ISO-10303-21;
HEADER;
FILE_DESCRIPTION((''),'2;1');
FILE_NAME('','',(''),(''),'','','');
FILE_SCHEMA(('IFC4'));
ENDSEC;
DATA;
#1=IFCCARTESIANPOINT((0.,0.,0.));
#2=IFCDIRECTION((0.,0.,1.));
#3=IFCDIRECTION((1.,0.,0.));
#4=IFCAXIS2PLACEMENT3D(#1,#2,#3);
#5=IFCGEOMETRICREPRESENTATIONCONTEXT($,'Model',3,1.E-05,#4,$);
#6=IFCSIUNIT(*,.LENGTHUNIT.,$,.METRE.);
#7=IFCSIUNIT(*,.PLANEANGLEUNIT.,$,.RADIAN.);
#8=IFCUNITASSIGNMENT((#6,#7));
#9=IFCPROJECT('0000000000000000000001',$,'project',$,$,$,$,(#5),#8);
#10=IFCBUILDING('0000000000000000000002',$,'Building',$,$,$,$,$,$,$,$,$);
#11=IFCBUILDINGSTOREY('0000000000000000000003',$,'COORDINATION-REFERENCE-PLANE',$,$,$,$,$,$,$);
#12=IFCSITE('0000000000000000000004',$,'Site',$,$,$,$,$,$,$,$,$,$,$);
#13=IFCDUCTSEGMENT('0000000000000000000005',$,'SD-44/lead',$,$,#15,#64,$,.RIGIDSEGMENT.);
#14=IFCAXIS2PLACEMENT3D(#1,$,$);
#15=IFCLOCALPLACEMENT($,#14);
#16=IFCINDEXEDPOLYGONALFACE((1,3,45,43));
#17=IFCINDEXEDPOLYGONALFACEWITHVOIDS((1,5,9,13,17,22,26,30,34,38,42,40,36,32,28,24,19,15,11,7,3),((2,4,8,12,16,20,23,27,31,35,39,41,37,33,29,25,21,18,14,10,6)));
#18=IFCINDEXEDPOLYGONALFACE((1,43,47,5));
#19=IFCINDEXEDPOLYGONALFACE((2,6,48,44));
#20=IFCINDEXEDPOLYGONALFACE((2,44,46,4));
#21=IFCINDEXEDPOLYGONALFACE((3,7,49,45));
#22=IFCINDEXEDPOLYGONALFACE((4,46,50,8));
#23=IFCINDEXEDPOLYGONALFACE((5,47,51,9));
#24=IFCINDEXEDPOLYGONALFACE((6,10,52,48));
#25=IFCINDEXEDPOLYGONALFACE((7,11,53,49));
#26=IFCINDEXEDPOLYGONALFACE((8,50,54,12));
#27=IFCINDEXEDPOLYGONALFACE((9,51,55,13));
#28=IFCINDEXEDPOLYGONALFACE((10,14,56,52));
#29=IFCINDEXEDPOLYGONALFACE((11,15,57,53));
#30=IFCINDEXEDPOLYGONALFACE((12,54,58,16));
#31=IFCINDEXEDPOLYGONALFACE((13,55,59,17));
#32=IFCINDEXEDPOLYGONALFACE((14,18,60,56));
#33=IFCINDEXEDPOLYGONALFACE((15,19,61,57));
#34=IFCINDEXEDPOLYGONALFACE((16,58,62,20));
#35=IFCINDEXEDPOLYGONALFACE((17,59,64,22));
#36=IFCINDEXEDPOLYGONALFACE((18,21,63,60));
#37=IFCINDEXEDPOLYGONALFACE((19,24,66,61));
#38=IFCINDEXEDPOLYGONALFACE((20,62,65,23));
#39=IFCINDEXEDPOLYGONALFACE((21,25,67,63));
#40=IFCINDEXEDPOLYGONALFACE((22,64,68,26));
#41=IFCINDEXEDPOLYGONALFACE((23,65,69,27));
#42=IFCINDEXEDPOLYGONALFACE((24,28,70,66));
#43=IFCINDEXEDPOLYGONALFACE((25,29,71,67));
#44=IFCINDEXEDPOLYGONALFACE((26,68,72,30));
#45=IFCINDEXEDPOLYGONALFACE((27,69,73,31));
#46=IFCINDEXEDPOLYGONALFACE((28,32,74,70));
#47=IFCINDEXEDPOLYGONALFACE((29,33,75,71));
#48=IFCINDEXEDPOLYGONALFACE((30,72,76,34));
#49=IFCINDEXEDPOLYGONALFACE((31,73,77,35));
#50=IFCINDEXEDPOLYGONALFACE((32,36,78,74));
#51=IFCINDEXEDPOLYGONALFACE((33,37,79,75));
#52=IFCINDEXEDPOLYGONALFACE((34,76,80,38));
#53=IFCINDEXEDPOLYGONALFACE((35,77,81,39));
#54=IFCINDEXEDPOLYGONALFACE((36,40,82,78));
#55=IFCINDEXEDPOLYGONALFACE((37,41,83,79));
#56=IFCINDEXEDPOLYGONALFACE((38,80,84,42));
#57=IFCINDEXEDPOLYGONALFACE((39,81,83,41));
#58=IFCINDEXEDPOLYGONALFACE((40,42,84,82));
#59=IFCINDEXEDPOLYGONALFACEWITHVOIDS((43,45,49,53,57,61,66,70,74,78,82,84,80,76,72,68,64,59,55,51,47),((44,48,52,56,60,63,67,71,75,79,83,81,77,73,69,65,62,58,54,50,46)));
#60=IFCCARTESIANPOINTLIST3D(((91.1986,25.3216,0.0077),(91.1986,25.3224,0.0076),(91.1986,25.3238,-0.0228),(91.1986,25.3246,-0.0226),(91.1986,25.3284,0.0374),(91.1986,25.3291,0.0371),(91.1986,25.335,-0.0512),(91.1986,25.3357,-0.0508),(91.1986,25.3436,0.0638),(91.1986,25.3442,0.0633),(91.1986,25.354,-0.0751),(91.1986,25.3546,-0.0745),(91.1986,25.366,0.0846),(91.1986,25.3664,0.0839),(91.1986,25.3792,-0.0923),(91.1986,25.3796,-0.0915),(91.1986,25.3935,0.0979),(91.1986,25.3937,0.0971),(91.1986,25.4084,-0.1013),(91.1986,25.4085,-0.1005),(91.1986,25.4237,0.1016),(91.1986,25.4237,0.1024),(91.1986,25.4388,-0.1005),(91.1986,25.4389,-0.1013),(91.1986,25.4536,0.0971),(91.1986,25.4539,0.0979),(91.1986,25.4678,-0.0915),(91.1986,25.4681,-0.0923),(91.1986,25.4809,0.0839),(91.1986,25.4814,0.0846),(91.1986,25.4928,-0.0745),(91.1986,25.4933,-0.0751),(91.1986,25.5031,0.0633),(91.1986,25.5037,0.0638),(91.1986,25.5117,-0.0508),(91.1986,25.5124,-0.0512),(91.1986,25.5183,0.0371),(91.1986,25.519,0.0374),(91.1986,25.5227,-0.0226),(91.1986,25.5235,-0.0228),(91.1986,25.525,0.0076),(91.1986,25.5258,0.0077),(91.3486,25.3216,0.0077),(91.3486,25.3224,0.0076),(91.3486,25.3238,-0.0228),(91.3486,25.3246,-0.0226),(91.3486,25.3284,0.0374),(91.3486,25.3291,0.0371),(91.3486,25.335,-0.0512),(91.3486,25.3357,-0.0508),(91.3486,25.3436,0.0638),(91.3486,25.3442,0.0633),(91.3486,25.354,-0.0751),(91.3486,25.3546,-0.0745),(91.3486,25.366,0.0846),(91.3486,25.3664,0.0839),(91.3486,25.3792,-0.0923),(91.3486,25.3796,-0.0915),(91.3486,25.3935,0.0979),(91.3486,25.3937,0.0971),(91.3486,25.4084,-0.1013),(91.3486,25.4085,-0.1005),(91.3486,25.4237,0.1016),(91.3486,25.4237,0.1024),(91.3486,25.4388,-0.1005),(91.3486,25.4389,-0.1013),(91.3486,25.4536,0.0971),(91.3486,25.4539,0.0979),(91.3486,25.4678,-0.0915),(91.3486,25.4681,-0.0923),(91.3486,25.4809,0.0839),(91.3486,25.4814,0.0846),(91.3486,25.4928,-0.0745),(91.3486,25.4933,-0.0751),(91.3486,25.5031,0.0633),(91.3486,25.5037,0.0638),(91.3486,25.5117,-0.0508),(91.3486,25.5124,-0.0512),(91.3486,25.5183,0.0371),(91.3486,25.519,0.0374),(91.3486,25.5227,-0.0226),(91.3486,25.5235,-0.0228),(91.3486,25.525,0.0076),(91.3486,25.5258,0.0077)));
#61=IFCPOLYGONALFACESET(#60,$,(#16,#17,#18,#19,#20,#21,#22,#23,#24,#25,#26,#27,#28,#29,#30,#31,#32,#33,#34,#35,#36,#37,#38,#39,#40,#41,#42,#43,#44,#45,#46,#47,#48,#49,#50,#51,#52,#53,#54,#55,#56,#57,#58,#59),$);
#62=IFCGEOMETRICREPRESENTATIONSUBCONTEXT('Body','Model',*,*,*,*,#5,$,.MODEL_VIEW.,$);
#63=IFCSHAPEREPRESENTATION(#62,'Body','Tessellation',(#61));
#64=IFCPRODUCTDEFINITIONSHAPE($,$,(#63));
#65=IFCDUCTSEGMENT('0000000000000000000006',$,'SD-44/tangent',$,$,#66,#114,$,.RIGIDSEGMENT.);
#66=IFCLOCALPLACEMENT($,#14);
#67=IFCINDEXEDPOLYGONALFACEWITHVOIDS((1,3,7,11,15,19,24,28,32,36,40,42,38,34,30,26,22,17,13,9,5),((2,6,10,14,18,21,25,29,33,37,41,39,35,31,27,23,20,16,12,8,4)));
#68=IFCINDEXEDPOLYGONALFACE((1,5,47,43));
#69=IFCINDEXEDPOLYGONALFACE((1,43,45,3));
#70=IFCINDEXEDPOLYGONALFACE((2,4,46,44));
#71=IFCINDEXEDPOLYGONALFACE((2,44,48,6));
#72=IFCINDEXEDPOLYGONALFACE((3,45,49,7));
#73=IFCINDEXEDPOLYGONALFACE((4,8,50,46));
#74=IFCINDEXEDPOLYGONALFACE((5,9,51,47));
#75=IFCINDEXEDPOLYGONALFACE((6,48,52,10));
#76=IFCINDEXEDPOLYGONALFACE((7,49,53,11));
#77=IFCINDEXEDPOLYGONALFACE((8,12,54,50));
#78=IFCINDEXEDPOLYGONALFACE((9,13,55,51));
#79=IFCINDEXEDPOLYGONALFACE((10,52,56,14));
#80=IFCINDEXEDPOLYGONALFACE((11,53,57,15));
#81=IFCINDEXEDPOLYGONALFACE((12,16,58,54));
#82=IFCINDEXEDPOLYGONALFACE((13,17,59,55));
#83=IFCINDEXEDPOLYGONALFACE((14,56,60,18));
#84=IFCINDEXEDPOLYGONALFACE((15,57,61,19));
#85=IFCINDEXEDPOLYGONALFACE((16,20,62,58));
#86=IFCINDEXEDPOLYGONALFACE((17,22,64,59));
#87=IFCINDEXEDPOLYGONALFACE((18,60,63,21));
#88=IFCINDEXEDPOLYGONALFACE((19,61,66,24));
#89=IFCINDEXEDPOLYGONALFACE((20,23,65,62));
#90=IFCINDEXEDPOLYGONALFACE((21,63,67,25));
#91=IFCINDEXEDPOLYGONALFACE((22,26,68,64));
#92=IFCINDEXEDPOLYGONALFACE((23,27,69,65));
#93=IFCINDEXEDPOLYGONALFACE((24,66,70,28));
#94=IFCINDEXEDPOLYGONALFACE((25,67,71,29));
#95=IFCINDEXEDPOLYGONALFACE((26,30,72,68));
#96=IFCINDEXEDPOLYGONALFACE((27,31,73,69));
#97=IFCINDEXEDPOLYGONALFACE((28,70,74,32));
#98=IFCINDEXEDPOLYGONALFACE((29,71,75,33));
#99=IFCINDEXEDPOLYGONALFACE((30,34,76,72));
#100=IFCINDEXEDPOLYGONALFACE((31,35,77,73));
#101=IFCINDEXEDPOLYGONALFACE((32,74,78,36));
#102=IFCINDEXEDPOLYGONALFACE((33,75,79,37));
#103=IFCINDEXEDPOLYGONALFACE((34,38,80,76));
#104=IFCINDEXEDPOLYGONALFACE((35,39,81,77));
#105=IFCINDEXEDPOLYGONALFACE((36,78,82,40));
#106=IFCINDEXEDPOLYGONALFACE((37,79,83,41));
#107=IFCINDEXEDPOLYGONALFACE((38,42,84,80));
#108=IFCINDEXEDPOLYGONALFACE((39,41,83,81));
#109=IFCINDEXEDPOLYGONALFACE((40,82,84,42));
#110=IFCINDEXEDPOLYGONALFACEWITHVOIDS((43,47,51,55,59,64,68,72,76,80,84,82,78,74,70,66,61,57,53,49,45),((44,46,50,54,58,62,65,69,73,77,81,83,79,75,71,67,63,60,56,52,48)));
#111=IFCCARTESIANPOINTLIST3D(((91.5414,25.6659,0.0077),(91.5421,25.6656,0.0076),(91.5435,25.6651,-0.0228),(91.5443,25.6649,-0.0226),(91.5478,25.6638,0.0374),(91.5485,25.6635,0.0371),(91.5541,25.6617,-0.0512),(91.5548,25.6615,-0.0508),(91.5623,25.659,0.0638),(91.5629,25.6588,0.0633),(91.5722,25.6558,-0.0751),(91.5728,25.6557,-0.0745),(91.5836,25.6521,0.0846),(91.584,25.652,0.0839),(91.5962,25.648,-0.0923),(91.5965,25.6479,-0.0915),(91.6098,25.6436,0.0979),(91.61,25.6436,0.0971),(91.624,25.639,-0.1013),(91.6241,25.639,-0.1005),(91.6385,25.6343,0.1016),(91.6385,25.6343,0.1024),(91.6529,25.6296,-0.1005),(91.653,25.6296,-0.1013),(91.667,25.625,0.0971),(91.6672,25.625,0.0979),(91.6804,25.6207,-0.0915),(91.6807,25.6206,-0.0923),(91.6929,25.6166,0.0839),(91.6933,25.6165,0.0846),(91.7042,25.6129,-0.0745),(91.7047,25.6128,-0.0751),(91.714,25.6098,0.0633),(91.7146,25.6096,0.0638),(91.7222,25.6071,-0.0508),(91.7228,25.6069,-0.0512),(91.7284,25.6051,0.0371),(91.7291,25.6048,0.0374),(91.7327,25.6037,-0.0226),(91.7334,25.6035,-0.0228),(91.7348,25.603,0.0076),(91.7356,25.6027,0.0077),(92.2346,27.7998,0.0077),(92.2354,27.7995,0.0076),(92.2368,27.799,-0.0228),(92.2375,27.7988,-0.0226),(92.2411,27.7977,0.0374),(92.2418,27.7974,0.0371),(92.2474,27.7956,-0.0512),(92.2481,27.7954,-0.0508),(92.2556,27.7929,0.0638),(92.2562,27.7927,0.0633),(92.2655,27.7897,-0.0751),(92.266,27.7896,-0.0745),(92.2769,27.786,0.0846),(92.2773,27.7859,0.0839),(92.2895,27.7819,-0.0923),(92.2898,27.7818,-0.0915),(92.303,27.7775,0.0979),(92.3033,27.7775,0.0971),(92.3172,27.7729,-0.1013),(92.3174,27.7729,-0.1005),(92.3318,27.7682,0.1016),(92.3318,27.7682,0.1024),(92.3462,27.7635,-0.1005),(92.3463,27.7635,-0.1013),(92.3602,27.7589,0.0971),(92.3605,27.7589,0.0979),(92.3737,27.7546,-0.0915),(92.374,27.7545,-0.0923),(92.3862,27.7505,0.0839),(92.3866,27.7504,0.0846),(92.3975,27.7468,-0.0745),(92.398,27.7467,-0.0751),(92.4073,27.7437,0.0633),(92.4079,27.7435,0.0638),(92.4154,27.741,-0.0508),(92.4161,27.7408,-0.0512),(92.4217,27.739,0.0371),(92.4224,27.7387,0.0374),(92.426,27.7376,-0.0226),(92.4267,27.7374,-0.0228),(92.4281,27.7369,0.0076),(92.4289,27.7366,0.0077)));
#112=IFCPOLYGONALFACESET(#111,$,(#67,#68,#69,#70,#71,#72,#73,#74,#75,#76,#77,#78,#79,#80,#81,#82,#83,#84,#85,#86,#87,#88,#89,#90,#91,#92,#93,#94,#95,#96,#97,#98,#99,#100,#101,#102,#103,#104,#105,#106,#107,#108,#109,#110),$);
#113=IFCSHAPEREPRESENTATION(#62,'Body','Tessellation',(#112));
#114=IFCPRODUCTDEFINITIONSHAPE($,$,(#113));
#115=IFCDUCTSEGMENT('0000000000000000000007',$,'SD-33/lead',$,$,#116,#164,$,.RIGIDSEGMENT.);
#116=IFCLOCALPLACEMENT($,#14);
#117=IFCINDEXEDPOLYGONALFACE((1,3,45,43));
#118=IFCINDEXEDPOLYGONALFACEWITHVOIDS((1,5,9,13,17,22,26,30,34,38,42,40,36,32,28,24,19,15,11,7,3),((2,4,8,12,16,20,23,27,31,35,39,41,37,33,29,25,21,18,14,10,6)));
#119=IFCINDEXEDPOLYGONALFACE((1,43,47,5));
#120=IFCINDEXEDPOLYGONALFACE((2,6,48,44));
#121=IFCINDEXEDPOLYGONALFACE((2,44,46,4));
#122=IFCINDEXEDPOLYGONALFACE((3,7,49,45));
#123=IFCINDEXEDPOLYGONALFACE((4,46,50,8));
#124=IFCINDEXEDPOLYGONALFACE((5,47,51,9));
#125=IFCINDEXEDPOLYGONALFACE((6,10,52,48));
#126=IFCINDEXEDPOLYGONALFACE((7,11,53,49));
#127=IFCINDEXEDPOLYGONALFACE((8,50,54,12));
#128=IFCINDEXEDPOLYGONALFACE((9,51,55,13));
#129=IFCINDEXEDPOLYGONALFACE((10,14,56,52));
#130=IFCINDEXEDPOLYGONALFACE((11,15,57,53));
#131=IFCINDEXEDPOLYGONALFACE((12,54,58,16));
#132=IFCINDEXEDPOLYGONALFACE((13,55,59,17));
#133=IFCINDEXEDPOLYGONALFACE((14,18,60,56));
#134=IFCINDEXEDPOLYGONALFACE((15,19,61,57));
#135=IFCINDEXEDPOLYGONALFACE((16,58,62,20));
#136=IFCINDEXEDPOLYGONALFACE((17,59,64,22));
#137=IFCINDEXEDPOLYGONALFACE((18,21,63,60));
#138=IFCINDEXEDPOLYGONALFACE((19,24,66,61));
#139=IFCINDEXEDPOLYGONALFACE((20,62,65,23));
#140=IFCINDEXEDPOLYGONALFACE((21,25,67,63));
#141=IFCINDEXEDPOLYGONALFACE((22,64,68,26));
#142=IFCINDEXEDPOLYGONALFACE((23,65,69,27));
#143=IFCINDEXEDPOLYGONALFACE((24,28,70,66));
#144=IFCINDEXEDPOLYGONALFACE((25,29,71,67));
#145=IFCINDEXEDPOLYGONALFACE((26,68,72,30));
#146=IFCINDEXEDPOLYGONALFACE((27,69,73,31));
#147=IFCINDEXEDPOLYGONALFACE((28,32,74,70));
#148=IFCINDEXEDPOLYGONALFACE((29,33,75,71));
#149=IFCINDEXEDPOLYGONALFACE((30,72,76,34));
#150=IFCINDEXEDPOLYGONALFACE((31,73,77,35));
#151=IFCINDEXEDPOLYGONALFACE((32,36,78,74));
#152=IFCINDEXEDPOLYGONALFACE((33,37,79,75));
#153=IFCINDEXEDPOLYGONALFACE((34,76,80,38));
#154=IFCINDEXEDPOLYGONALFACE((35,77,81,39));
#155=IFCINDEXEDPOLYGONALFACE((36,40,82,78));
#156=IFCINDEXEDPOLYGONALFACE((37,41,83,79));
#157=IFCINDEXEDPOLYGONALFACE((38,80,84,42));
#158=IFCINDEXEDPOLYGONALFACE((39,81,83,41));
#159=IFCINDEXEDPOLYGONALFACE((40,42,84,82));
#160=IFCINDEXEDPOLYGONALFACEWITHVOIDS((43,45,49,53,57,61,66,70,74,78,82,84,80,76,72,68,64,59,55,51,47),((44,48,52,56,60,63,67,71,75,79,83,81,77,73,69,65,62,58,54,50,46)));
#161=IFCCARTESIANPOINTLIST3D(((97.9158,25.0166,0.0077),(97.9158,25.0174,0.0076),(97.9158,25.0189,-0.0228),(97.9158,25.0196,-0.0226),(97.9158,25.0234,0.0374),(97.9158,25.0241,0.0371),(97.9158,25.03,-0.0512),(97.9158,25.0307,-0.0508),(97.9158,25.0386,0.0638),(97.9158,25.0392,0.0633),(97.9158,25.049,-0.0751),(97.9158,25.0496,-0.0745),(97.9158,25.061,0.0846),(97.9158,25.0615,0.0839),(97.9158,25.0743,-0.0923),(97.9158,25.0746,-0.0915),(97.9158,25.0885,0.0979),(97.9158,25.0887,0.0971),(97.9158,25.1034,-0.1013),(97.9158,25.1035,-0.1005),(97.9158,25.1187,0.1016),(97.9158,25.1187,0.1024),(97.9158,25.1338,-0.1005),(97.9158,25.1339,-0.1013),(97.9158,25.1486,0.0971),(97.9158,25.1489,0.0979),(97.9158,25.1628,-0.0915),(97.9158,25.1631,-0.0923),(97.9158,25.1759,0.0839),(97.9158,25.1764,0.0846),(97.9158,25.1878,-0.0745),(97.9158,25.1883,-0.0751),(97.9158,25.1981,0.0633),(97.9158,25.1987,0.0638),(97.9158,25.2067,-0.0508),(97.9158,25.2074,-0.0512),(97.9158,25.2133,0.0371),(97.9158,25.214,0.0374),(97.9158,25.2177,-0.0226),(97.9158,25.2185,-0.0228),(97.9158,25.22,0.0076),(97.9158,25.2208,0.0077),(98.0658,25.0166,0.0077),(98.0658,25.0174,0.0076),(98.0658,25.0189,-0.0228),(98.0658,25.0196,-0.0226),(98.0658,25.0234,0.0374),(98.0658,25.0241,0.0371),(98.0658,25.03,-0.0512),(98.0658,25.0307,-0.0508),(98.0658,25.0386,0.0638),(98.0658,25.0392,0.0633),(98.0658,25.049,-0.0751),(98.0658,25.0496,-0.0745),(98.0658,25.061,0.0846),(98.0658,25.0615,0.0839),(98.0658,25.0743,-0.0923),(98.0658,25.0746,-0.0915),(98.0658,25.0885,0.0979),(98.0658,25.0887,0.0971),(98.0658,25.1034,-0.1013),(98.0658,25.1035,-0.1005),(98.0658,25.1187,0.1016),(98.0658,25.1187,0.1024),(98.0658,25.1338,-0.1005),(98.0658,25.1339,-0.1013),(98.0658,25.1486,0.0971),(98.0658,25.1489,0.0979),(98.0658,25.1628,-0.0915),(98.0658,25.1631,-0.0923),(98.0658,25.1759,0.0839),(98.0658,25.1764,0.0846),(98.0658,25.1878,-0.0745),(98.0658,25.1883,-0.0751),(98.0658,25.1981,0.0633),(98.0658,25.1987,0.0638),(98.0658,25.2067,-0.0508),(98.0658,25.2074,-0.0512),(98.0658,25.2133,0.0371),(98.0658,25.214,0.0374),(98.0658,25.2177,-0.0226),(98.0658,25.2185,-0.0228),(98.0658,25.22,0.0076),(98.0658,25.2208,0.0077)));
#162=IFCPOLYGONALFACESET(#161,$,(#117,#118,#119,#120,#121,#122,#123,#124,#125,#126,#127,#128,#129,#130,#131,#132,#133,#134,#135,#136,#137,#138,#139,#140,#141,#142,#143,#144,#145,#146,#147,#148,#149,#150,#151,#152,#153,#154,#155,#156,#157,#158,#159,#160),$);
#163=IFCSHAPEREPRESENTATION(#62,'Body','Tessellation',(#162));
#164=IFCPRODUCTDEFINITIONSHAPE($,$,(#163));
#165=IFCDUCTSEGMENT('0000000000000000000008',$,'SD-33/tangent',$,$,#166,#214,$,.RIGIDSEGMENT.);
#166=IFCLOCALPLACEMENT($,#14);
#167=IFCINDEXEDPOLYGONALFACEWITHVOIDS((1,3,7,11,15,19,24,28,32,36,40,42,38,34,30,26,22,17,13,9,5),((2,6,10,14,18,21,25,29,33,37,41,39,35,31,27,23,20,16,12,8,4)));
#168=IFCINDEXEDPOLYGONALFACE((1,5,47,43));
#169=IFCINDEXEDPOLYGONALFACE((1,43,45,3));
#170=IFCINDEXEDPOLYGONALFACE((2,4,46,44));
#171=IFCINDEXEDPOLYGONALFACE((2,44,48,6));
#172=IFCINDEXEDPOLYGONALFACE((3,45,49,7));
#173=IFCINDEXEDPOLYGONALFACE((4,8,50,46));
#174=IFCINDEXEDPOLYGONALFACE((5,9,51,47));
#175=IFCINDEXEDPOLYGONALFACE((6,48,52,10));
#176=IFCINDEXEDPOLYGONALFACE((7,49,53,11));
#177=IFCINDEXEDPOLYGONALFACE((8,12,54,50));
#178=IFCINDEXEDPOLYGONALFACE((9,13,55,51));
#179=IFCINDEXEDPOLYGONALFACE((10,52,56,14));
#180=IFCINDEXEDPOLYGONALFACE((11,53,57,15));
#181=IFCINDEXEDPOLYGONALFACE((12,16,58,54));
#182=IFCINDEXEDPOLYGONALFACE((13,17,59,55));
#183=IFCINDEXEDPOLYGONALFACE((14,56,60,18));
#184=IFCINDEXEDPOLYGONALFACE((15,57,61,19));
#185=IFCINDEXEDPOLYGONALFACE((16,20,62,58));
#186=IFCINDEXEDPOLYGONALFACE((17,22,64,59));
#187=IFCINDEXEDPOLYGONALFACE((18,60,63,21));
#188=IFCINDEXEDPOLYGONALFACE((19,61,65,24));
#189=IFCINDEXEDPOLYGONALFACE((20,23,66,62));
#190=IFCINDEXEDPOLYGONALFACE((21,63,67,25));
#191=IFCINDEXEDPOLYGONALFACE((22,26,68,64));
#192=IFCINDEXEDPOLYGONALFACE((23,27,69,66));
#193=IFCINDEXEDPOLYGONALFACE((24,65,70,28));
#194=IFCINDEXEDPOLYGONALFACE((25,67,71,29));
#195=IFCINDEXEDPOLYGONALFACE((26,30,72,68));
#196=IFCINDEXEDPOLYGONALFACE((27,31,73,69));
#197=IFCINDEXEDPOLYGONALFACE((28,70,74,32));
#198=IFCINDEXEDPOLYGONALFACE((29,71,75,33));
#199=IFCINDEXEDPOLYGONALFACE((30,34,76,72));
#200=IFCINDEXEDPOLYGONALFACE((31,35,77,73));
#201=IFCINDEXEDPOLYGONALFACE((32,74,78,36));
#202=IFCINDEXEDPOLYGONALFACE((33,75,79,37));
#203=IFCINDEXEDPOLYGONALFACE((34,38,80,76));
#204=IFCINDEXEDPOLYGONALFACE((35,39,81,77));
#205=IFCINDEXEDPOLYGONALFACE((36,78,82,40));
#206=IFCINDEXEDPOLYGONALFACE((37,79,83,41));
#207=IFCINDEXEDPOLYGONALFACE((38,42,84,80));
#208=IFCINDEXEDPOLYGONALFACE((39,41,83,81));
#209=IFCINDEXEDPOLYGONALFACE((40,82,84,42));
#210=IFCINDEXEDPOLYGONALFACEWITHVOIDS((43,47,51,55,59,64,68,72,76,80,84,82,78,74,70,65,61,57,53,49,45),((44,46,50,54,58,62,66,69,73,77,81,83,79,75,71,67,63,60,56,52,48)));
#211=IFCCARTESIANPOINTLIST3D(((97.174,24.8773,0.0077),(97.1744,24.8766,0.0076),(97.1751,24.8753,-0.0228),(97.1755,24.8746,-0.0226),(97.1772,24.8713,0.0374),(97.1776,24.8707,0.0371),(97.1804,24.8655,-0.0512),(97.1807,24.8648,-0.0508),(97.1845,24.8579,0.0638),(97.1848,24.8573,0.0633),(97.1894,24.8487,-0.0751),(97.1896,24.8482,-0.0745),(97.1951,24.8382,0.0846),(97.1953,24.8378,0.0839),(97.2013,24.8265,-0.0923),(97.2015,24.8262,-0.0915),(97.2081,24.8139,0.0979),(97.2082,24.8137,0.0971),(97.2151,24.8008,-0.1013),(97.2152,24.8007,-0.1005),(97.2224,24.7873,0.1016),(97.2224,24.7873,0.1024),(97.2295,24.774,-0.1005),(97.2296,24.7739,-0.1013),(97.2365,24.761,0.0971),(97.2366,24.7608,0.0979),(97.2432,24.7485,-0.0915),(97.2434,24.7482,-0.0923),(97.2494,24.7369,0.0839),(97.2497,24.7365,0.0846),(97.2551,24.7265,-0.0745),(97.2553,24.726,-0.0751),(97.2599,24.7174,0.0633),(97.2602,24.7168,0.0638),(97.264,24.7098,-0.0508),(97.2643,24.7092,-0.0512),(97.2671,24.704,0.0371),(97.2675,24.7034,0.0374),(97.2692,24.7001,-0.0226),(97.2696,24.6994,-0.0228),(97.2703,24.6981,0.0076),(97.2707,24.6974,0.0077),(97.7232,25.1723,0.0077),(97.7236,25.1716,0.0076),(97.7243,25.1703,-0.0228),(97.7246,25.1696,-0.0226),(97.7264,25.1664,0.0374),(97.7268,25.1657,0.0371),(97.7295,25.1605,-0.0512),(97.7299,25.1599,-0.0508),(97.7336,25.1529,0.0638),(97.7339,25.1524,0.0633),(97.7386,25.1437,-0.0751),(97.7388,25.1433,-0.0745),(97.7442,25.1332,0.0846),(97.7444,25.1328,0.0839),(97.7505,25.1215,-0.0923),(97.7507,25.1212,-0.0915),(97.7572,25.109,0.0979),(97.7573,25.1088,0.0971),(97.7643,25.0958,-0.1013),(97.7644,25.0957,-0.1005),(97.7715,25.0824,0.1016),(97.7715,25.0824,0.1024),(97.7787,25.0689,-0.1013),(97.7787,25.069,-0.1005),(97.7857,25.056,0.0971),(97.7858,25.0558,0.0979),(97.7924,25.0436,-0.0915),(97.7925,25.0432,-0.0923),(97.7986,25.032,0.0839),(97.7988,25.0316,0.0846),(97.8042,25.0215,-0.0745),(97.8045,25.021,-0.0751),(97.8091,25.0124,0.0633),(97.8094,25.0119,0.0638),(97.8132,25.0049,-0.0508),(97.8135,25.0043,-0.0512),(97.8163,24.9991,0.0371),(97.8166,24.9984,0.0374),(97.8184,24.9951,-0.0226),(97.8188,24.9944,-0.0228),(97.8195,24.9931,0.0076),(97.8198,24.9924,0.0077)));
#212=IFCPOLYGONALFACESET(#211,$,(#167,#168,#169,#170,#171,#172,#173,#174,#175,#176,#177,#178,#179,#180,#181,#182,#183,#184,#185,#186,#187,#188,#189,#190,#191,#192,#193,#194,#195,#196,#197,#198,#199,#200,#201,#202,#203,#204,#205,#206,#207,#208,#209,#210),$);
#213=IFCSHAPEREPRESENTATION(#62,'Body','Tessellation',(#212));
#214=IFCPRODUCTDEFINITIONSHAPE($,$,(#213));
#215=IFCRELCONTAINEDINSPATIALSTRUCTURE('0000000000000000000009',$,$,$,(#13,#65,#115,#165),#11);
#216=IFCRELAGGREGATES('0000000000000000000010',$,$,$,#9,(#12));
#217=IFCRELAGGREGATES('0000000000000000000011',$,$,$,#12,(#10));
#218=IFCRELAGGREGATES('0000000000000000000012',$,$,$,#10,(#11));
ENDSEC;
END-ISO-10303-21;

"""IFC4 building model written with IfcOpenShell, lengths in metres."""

from ifc_helpers import new_model, si_unit, frame, origin_with_axes, place, context, subcontext, project, spatial, hollow_circle, extrude, element, save


model = new_model("IFC4")

# Units and contexts
model_context_1 = context("Model", 3, precision=1e-05, world=origin_with_axes())
body_context_1 = subcontext(model_context_1, "Body", "Model", "MODEL_VIEW")
ifc_project = project(units=[si_unit("LENGTHUNIT", "METRE"), si_unit("PLANEANGLEUNIT", "RADIAN")], contexts=[model_context_1])

# Site, building, storey
site = spatial("IfcSite", under=ifc_project, Name="Site")
building = spatial("IfcBuilding", under=site, Name="Building")
storey = spatial("IfcBuildingStorey", under=building, Name="COORDINATION-REFERENCE-PLANE")

# Duct segment
for number, where, z_axis, x_axis, name in (
    (1, (91.1986, 25.4237, 0.0), (1.0, 0.0, 0.0), (0.0, 0.0, 1.0), "SD-44/lead"),
):
    element("IfcDuctSegment", number, at=place(None, frame(where, z_axis=z_axis, x_axis=x_axis)), inside=storey, Name=name, PredefinedType="RIGIDSEGMENT", context=body_context_1, shape_type="SweptSolid", body=[
        extrude(hollow_circle(Radius=0.1024, WallThickness=0.0008), origin_with_axes(), (0.0, 0.0, 1.0), 0.15),
    ])

# Duct segments
duct_segment_1_placement = place(None, frame((91.6385, 25.6343, 0.0), z_axis=(0.30899, 0.951065, 0.0), x_axis=(0.0, 0.0, 1.0)))
element("IfcDuctSegment", 2, at=duct_segment_1_placement, inside=storey, Name="SD-44/tangent", PredefinedType="RIGIDSEGMENT", context=body_context_1, shape_type="SweptSolid", body=[
    extrude(hollow_circle(Radius=0.1024, WallThickness=0.0008), origin_with_axes(), (0.0, 0.0, 1.0), 2.2437),
])
duct_segment_2_placement = place(None, frame((98.0658, 25.1187, 0.0), z_axis=(-1.0, 0.0, 0.0), x_axis=(0.0, 0.0, 1.0)))
element("IfcDuctSegment", 3, at=duct_segment_2_placement, inside=storey, Name="SD-33/lead", PredefinedType="RIGIDSEGMENT", context=body_context_1, shape_type="SweptSolid", body=[
    extrude(hollow_circle(Radius=0.1024, WallThickness=0.0008), origin_with_axes(), (0.0, 0.0, 1.0), 0.15),
])

# Duct segment
duct_segment_3_placement = place(None, frame((97.7715, 25.0824, 0.0), z_axis=(-0.880912, -0.473279, 0.0), x_axis=(0.0, 0.0, 1.0)))
element("IfcDuctSegment", 4, at=duct_segment_3_placement, inside=storey, Name="SD-33/tangent", PredefinedType="RIGIDSEGMENT", context=body_context_1, shape_type="SweptSolid", body=[
    extrude(hollow_circle(Radius=0.1024, WallThickness=0.0008), origin_with_axes(), (0.0, 0.0, 1.0), 0.6234),
])

save(model, "model.ifc")
